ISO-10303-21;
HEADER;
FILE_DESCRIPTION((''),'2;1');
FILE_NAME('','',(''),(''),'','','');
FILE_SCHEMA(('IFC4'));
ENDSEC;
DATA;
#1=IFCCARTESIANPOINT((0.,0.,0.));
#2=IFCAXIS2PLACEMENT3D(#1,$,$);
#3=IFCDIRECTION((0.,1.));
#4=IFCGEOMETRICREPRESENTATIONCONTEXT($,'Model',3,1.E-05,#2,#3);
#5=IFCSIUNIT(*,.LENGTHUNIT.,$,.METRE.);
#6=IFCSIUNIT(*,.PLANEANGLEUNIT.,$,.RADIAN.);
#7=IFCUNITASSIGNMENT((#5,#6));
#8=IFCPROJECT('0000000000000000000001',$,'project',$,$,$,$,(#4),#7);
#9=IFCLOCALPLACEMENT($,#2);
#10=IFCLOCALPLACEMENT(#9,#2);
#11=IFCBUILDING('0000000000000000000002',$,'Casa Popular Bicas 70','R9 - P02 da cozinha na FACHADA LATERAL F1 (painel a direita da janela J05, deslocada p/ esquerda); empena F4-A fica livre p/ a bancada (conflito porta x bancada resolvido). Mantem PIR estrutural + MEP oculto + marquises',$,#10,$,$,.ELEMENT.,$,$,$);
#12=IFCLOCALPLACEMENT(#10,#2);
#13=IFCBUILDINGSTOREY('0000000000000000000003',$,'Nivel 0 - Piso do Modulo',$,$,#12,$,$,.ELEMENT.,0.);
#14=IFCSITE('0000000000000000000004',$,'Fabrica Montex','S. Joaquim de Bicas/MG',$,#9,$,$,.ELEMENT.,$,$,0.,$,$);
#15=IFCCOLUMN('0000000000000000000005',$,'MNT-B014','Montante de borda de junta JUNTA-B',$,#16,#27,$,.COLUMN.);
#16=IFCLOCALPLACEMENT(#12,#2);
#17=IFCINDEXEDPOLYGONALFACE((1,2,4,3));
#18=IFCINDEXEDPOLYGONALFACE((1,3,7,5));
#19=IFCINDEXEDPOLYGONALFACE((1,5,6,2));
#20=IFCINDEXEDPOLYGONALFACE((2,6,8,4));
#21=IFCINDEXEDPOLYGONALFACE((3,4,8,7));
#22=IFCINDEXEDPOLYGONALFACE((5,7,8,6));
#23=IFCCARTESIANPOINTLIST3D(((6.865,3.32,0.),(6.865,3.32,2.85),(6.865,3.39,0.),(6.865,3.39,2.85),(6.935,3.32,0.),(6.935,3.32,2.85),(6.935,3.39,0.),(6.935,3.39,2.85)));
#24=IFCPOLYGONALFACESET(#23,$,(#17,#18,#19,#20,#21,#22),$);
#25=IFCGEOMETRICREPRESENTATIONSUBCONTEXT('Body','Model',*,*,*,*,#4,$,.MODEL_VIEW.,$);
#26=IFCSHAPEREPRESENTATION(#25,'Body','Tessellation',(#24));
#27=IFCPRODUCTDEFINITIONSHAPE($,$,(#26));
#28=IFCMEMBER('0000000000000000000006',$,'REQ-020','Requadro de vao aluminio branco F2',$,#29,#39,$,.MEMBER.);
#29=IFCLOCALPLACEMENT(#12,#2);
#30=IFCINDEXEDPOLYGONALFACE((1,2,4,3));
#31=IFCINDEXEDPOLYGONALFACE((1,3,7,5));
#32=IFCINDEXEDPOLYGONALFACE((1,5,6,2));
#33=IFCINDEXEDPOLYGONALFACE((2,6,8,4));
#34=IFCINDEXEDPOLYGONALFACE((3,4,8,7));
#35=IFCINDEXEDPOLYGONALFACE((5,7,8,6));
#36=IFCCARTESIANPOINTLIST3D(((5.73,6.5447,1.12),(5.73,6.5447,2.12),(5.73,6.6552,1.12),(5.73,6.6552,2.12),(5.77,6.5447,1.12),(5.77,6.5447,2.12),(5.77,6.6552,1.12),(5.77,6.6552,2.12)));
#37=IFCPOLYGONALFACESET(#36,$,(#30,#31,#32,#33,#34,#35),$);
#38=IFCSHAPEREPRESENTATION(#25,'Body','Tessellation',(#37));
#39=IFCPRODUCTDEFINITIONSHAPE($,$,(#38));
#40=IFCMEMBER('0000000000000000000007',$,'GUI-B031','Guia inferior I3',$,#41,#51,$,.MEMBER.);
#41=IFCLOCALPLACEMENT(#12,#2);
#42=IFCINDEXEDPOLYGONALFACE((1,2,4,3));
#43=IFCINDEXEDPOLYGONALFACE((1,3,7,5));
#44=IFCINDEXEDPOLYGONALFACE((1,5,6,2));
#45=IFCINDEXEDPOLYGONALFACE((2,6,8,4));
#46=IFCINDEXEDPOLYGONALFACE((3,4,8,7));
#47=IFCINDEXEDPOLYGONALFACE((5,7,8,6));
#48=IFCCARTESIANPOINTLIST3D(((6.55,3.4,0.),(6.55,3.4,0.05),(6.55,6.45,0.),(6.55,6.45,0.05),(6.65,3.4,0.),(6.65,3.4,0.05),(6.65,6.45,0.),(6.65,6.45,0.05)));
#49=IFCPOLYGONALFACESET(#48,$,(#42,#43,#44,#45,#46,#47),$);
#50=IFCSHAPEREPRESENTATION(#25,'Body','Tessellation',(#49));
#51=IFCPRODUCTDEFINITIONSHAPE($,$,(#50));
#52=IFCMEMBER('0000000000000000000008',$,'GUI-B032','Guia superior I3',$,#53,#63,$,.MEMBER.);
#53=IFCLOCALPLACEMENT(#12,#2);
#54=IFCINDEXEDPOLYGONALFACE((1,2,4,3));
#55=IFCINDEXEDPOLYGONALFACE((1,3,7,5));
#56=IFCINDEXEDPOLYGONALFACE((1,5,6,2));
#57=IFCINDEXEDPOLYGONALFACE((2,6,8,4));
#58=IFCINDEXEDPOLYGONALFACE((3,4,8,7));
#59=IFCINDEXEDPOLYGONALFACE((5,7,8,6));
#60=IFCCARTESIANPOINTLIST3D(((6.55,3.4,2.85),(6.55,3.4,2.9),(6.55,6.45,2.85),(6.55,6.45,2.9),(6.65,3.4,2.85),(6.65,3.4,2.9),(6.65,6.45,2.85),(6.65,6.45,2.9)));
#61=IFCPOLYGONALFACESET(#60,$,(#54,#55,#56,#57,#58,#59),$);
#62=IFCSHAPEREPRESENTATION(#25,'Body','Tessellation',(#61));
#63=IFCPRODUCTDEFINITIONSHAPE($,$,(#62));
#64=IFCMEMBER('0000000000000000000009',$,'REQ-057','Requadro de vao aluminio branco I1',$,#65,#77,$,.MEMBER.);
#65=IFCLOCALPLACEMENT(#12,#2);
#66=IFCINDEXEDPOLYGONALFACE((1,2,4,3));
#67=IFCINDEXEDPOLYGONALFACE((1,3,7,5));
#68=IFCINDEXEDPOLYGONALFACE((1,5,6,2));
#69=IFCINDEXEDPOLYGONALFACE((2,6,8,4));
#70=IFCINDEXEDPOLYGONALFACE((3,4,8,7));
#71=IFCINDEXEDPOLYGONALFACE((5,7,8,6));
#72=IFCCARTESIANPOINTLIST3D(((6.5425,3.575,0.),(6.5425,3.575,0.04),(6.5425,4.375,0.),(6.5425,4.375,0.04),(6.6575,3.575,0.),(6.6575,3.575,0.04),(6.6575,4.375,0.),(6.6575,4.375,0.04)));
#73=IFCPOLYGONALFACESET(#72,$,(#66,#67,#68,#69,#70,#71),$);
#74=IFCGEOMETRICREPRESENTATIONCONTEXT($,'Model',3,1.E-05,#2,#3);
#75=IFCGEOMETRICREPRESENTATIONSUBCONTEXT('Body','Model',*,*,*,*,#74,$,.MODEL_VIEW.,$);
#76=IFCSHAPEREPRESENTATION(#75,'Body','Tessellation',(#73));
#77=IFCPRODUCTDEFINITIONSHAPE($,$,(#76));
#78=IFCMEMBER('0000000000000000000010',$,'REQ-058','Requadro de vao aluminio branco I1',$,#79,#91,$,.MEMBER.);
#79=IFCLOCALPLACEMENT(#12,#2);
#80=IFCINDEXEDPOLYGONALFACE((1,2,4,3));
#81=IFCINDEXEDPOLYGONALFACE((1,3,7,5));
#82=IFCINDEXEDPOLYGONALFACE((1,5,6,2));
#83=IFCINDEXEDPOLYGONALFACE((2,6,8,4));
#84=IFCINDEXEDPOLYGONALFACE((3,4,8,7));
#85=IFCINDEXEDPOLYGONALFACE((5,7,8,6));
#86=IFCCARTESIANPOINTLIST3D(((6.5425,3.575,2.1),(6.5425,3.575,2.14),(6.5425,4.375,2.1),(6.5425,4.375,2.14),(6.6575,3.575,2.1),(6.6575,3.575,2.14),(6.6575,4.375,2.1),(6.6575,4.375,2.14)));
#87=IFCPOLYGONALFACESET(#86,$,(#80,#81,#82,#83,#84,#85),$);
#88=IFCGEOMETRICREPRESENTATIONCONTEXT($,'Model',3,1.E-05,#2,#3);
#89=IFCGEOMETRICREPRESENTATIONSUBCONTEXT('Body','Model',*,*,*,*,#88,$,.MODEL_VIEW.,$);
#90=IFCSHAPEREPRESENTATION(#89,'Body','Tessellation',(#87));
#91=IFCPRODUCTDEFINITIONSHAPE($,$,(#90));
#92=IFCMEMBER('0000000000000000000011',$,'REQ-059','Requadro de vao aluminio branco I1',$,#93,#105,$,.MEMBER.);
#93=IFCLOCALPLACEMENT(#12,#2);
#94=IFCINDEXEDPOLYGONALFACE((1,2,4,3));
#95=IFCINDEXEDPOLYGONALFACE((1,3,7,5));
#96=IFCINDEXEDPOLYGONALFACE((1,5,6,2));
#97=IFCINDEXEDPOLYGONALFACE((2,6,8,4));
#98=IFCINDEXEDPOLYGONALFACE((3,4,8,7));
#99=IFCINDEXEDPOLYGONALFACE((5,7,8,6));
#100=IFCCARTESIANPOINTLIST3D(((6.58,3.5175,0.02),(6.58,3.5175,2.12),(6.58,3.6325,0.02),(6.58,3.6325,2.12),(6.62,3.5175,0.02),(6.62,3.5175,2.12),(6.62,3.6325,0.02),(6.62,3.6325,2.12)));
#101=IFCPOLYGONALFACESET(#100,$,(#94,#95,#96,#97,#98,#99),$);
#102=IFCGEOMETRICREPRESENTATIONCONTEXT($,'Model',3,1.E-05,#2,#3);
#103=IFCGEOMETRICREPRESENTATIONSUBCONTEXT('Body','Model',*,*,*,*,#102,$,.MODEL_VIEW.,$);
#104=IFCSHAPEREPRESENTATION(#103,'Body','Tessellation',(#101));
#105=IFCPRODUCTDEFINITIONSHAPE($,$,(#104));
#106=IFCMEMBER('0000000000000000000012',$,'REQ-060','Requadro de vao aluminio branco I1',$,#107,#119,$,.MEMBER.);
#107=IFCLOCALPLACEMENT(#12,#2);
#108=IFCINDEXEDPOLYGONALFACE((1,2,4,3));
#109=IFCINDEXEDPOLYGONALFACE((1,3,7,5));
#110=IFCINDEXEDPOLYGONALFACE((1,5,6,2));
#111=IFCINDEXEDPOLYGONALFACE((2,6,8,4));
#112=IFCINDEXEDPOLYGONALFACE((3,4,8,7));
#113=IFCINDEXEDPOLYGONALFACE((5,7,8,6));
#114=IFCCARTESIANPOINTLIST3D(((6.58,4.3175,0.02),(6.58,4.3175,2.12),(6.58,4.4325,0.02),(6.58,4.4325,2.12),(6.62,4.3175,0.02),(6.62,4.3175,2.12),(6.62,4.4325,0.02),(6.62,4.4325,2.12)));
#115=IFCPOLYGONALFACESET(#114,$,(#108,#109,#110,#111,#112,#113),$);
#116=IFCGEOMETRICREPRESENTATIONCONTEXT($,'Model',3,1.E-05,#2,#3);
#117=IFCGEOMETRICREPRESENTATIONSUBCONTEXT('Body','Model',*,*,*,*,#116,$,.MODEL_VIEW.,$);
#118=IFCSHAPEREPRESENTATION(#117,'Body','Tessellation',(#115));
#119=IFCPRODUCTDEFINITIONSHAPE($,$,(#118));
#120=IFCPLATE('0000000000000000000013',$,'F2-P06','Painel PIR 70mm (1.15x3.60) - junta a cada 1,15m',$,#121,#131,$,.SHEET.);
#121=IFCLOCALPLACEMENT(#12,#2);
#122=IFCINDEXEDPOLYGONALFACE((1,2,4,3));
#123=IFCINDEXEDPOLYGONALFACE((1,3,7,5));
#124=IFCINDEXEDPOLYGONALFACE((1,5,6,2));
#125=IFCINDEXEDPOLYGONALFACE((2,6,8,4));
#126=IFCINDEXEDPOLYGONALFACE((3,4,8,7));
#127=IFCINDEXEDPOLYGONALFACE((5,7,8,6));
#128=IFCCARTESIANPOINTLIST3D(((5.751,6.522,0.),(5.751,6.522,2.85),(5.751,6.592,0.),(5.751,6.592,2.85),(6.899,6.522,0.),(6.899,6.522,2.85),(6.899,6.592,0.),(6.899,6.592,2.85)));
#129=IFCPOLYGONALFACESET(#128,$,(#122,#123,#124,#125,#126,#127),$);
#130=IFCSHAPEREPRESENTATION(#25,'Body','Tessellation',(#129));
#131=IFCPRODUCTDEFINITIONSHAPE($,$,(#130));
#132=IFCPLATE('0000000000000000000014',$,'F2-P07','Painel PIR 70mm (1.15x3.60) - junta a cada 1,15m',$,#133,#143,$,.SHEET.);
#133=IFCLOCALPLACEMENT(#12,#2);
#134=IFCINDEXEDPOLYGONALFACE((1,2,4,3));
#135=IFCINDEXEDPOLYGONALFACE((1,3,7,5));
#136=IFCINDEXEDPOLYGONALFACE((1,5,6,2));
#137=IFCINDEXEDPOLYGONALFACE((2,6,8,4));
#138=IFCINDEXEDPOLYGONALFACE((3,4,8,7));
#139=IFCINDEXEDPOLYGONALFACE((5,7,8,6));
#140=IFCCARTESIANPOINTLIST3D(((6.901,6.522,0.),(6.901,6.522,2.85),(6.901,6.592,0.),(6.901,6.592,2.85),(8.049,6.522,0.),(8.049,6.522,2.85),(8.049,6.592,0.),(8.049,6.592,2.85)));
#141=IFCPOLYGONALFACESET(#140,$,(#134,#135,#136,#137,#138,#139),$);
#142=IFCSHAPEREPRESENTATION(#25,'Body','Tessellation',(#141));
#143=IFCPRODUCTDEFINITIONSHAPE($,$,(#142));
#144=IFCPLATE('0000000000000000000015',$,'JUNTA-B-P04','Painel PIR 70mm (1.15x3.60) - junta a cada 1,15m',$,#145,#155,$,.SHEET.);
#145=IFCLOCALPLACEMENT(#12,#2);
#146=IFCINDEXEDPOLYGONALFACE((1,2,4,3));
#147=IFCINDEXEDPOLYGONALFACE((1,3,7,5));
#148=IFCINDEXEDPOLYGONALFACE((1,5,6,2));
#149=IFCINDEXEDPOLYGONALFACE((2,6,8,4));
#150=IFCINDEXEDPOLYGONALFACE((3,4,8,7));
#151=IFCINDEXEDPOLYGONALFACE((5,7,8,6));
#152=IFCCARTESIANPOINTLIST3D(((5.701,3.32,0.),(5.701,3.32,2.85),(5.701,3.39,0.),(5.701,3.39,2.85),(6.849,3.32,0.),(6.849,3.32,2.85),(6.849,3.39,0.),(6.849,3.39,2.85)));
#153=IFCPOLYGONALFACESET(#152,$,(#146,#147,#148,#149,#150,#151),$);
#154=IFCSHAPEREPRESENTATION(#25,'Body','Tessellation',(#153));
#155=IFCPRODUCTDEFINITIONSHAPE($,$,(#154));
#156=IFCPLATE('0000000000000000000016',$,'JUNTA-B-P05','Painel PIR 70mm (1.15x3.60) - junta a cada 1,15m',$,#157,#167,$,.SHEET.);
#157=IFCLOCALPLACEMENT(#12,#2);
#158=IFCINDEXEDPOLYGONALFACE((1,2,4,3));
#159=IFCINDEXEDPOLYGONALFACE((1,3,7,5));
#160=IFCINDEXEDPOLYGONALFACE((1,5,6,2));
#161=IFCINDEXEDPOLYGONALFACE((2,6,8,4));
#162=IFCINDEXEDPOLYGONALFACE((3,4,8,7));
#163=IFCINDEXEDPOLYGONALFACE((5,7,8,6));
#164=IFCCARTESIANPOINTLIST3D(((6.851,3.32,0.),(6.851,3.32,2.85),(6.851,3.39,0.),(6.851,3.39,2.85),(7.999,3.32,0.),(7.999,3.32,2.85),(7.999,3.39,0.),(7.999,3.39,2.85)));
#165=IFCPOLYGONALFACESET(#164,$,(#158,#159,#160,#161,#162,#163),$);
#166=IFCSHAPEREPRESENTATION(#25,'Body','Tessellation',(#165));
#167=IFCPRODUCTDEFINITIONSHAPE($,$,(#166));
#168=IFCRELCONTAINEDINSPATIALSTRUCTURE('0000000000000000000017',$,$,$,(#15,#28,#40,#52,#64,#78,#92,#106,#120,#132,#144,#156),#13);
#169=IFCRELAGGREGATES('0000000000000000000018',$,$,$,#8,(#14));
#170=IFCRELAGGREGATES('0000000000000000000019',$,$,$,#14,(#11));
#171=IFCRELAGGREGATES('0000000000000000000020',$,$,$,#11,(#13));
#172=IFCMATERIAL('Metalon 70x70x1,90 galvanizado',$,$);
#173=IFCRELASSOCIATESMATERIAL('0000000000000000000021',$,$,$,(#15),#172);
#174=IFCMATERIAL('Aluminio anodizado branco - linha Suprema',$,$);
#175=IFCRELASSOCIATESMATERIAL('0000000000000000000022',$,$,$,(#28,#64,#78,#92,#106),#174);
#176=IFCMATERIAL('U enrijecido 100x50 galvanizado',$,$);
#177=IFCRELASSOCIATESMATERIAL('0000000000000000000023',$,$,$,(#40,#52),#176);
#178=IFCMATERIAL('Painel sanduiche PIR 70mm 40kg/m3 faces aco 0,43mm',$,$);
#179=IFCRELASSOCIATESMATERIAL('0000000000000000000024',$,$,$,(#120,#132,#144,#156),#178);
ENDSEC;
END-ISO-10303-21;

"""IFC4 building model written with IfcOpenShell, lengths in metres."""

from ifc_helpers import new_model, si_unit, direction, frame, frame_2d, origin, origin_2d, place, context, subcontext, project, spatial, rectangle, extrude, material, element, save


model = new_model("IFC4")

# Units and contexts
model_context_1 = context("Model", 3, precision=1e-05, world=origin(), true_north=direction((0.0, 1.0)))
model_context_2 = context("Model", 3, precision=1e-05, world=origin(), true_north=direction((0.0, 1.0)))
model_context_3 = context("Model", 3, precision=1e-05, world=origin(), true_north=direction((0.0, 1.0)))
model_context_4 = context("Model", 3, precision=1e-05, world=origin(), true_north=direction((0.0, 1.0)))
model_context_5 = context("Model", 3, precision=1e-05, world=origin(), true_north=direction((0.0, 1.0)))
body_context_1 = subcontext(model_context_1, "Body", "Model", "MODEL_VIEW")
body_context_2 = subcontext(model_context_2, "Body", "Model", "MODEL_VIEW")
body_context_3 = subcontext(model_context_3, "Body", "Model", "MODEL_VIEW")
body_context_4 = subcontext(model_context_4, "Body", "Model", "MODEL_VIEW")
body_context_5 = subcontext(model_context_5, "Body", "Model", "MODEL_VIEW")
ifc_project = project(units=[si_unit("LENGTHUNIT", "METRE"), si_unit("PLANEANGLEUNIT", "RADIAN")], contexts=[model_context_1])

# Site, building, storey
site_placement = place(None, origin())
site = spatial("IfcSite", under=ifc_project, at=site_placement, Name="Fabrica Montex", Description="S. Joaquim de Bicas/MG", CompositionType="ELEMENT", RefElevation=0.0)
building_placement = place(site_placement, origin())
building = spatial("IfcBuilding", under=site, at=building_placement, Name="Casa Popular Bicas 70", Description="R9 - P02 da cozinha na FACHADA LATERAL F1 (painel a direita da janela J05, deslocada p/ esquerda); empena F4-A fica livre p/ a bancada (conflito porta x bancada resolvido). Mantem PIR estrutural + MEP oculto + marquises", CompositionType="ELEMENT")
storey_placement = place(building_placement, origin())
storey = spatial("IfcBuildingStorey", under=building, at=storey_placement, Name="Nivel 0 - Piso do Modulo", CompositionType="ELEMENT", Elevation=0.0)

# Column
ifc_material_1 = material(Name="Metalon 70x70x1,90 galvanizado")
column_placement = place(storey_placement, frame((6.9, 3.355, 0.0)))
element("IfcColumn", 1, at=column_placement, inside=storey, material=ifc_material_1, Name="MNT-B014", Description="Montante de borda de junta JUNTA-B", PredefinedType="COLUMN", context=body_context_1, shape_type="SweptSolid", body=[
    extrude(rectangle(XDim=0.07, YDim=0.07, at=origin_2d()), origin(), (0.0, 0.0, 1.0), 2.85),
])

# Members
ifc_material_2 = material(Name="Aluminio anodizado branco - linha Suprema")
member_1_placement = place(storey_placement, frame((5.75, 6.6, 1.12), z_axis=(0.0, 0.0, 1.0), x_axis=(1.0, 0.0, 0.0)))
element("IfcMember", 2, at=member_1_placement, inside=storey, material=ifc_material_2, Name="REQ-020", Description="Requadro de vao aluminio branco F2", PredefinedType="MEMBER", context=body_context_1, shape_type="SweptSolid", body=[
    extrude(rectangle(XDim=0.04, YDim=0.1105, at=origin_2d()), origin(), (0.0, 0.0, 1.0), 1.0),
])
ifc_material_3 = material(Name="U enrijecido 100x50 galvanizado")
for number, where, z_axis, x_axis, name, description in (
    (3, (6.6, 3.4, 0.025), (0.0, 1.0, 0.0), (0.0, 0.0, 1.0), "GUI-B031", "Guia inferior I3"),
    (4, (6.6, 3.4, 2.875), (0.0, 1.0, 0.0), (0.0, 0.0, 1.0), "GUI-B032", "Guia superior I3"),
):
    element("IfcMember", number, at=place(storey_placement, frame(where, z_axis=z_axis, x_axis=x_axis)), inside=storey, material=ifc_material_3, Name=name, Description=description, PredefinedType="MEMBER", context=body_context_1, shape_type="SweptSolid", body=[
        extrude(rectangle(XDim=0.05, YDim=0.1, at=origin_2d()), origin(), (0.0, 0.0, 1.0), 3.05),
    ])
placement_1 = place(None, origin())
placement_2 = place(placement_1, origin())
placement_3 = place(placement_2, origin())
member_2_placement = place(placement_3, frame((6.6, 3.575, 0.02), z_axis=(0.0, 1.0, 0.0), x_axis=(0.0, 0.0, 1.0)))
element("IfcMember", 5, at=member_2_placement, inside=storey, material=ifc_material_2, Name="REQ-057", Description="Requadro de vao aluminio branco I1", PredefinedType="MEMBER", context=body_context_2, shape_type="SweptSolid", body=[
    extrude(rectangle(XDim=0.04, YDim=0.115, at=origin_2d()), origin(), (0.0, 0.0, 1.0), 0.8),
])
placement_4 = place(None, origin())
placement_5 = place(placement_4, origin())
placement_6 = place(placement_5, origin())
member_3_placement = place(placement_6, frame((6.6, 3.575, 2.12), z_axis=(0.0, 1.0, 0.0), x_axis=(0.0, 0.0, 1.0)))
element("IfcMember", 6, at=member_3_placement, inside=storey, material=ifc_material_2, Name="REQ-058", Description="Requadro de vao aluminio branco I1", PredefinedType="MEMBER", context=body_context_3, shape_type="SweptSolid", body=[
    extrude(rectangle(XDim=0.04, YDim=0.115, at=origin_2d()), origin(), (0.0, 0.0, 1.0), 0.8),
])
placement_7 = place(None, origin())
placement_8 = place(placement_7, origin())
placement_9 = place(placement_8, origin())
member_4_placement = place(placement_9, frame((6.6, 3.575, 0.02), z_axis=(0.0, 0.0, 1.0), x_axis=(1.0, 0.0, 0.0)))
element("IfcMember", 7, at=member_4_placement, inside=storey, material=ifc_material_2, Name="REQ-059", Description="Requadro de vao aluminio branco I1", PredefinedType="MEMBER", context=body_context_4, shape_type="SweptSolid", body=[
    extrude(rectangle(XDim=0.04, YDim=0.115, at=origin_2d()), origin(), (0.0, 0.0, 1.0), 2.1),
])
placement_10 = place(None, origin())
placement_11 = place(placement_10, origin())
placement_12 = place(placement_11, origin())
member_5_placement = place(placement_12, frame((6.6, 4.375, 0.02), z_axis=(0.0, 0.0, 1.0), x_axis=(1.0, 0.0, 0.0)))
element("IfcMember", 8, at=member_5_placement, inside=storey, material=ifc_material_2, Name="REQ-060", Description="Requadro de vao aluminio branco I1", PredefinedType="MEMBER", context=body_context_5, shape_type="SweptSolid", body=[
    extrude(rectangle(XDim=0.04, YDim=0.115, at=origin_2d()), origin(), (0.0, 0.0, 1.0), 2.1),
])

# Plates
ifc_material_4 = material(Name="Painel sanduiche PIR 70mm 40kg/m3 faces aco 0,43mm")
for number, where, x_axis, name in (
    (9, (5.751, 6.557, 0.0), (1.0, 0.0, 0.0), "F2-P06"),
    (10, (6.901, 6.557, 0.0), (1.0, 0.0, 0.0), "F2-P07"),
    (11, (5.701, 3.355, 0.0), (1.0, 0.0, 0.0), "JUNTA-B-P04"),
    (12, (6.851, 3.355, 0.0), (1.0, 0.0, 0.0), "JUNTA-B-P05"),
):
    element("IfcPlate", number, at=place(storey_placement, frame(where, x_axis=x_axis)), inside=storey, material=ifc_material_4, Name=name, Description="Painel PIR 70mm (1.15x3.60) - junta a cada 1,15m", PredefinedType="SHEET", context=body_context_1, shape_type="SweptSolid", body=[
        extrude(rectangle(XDim=1.148, YDim=0.07, at=frame_2d((0.574, 0.0))), origin(), (0.0, 0.0, 1.0), 2.85),
    ])

save(model, "model.ifc")
